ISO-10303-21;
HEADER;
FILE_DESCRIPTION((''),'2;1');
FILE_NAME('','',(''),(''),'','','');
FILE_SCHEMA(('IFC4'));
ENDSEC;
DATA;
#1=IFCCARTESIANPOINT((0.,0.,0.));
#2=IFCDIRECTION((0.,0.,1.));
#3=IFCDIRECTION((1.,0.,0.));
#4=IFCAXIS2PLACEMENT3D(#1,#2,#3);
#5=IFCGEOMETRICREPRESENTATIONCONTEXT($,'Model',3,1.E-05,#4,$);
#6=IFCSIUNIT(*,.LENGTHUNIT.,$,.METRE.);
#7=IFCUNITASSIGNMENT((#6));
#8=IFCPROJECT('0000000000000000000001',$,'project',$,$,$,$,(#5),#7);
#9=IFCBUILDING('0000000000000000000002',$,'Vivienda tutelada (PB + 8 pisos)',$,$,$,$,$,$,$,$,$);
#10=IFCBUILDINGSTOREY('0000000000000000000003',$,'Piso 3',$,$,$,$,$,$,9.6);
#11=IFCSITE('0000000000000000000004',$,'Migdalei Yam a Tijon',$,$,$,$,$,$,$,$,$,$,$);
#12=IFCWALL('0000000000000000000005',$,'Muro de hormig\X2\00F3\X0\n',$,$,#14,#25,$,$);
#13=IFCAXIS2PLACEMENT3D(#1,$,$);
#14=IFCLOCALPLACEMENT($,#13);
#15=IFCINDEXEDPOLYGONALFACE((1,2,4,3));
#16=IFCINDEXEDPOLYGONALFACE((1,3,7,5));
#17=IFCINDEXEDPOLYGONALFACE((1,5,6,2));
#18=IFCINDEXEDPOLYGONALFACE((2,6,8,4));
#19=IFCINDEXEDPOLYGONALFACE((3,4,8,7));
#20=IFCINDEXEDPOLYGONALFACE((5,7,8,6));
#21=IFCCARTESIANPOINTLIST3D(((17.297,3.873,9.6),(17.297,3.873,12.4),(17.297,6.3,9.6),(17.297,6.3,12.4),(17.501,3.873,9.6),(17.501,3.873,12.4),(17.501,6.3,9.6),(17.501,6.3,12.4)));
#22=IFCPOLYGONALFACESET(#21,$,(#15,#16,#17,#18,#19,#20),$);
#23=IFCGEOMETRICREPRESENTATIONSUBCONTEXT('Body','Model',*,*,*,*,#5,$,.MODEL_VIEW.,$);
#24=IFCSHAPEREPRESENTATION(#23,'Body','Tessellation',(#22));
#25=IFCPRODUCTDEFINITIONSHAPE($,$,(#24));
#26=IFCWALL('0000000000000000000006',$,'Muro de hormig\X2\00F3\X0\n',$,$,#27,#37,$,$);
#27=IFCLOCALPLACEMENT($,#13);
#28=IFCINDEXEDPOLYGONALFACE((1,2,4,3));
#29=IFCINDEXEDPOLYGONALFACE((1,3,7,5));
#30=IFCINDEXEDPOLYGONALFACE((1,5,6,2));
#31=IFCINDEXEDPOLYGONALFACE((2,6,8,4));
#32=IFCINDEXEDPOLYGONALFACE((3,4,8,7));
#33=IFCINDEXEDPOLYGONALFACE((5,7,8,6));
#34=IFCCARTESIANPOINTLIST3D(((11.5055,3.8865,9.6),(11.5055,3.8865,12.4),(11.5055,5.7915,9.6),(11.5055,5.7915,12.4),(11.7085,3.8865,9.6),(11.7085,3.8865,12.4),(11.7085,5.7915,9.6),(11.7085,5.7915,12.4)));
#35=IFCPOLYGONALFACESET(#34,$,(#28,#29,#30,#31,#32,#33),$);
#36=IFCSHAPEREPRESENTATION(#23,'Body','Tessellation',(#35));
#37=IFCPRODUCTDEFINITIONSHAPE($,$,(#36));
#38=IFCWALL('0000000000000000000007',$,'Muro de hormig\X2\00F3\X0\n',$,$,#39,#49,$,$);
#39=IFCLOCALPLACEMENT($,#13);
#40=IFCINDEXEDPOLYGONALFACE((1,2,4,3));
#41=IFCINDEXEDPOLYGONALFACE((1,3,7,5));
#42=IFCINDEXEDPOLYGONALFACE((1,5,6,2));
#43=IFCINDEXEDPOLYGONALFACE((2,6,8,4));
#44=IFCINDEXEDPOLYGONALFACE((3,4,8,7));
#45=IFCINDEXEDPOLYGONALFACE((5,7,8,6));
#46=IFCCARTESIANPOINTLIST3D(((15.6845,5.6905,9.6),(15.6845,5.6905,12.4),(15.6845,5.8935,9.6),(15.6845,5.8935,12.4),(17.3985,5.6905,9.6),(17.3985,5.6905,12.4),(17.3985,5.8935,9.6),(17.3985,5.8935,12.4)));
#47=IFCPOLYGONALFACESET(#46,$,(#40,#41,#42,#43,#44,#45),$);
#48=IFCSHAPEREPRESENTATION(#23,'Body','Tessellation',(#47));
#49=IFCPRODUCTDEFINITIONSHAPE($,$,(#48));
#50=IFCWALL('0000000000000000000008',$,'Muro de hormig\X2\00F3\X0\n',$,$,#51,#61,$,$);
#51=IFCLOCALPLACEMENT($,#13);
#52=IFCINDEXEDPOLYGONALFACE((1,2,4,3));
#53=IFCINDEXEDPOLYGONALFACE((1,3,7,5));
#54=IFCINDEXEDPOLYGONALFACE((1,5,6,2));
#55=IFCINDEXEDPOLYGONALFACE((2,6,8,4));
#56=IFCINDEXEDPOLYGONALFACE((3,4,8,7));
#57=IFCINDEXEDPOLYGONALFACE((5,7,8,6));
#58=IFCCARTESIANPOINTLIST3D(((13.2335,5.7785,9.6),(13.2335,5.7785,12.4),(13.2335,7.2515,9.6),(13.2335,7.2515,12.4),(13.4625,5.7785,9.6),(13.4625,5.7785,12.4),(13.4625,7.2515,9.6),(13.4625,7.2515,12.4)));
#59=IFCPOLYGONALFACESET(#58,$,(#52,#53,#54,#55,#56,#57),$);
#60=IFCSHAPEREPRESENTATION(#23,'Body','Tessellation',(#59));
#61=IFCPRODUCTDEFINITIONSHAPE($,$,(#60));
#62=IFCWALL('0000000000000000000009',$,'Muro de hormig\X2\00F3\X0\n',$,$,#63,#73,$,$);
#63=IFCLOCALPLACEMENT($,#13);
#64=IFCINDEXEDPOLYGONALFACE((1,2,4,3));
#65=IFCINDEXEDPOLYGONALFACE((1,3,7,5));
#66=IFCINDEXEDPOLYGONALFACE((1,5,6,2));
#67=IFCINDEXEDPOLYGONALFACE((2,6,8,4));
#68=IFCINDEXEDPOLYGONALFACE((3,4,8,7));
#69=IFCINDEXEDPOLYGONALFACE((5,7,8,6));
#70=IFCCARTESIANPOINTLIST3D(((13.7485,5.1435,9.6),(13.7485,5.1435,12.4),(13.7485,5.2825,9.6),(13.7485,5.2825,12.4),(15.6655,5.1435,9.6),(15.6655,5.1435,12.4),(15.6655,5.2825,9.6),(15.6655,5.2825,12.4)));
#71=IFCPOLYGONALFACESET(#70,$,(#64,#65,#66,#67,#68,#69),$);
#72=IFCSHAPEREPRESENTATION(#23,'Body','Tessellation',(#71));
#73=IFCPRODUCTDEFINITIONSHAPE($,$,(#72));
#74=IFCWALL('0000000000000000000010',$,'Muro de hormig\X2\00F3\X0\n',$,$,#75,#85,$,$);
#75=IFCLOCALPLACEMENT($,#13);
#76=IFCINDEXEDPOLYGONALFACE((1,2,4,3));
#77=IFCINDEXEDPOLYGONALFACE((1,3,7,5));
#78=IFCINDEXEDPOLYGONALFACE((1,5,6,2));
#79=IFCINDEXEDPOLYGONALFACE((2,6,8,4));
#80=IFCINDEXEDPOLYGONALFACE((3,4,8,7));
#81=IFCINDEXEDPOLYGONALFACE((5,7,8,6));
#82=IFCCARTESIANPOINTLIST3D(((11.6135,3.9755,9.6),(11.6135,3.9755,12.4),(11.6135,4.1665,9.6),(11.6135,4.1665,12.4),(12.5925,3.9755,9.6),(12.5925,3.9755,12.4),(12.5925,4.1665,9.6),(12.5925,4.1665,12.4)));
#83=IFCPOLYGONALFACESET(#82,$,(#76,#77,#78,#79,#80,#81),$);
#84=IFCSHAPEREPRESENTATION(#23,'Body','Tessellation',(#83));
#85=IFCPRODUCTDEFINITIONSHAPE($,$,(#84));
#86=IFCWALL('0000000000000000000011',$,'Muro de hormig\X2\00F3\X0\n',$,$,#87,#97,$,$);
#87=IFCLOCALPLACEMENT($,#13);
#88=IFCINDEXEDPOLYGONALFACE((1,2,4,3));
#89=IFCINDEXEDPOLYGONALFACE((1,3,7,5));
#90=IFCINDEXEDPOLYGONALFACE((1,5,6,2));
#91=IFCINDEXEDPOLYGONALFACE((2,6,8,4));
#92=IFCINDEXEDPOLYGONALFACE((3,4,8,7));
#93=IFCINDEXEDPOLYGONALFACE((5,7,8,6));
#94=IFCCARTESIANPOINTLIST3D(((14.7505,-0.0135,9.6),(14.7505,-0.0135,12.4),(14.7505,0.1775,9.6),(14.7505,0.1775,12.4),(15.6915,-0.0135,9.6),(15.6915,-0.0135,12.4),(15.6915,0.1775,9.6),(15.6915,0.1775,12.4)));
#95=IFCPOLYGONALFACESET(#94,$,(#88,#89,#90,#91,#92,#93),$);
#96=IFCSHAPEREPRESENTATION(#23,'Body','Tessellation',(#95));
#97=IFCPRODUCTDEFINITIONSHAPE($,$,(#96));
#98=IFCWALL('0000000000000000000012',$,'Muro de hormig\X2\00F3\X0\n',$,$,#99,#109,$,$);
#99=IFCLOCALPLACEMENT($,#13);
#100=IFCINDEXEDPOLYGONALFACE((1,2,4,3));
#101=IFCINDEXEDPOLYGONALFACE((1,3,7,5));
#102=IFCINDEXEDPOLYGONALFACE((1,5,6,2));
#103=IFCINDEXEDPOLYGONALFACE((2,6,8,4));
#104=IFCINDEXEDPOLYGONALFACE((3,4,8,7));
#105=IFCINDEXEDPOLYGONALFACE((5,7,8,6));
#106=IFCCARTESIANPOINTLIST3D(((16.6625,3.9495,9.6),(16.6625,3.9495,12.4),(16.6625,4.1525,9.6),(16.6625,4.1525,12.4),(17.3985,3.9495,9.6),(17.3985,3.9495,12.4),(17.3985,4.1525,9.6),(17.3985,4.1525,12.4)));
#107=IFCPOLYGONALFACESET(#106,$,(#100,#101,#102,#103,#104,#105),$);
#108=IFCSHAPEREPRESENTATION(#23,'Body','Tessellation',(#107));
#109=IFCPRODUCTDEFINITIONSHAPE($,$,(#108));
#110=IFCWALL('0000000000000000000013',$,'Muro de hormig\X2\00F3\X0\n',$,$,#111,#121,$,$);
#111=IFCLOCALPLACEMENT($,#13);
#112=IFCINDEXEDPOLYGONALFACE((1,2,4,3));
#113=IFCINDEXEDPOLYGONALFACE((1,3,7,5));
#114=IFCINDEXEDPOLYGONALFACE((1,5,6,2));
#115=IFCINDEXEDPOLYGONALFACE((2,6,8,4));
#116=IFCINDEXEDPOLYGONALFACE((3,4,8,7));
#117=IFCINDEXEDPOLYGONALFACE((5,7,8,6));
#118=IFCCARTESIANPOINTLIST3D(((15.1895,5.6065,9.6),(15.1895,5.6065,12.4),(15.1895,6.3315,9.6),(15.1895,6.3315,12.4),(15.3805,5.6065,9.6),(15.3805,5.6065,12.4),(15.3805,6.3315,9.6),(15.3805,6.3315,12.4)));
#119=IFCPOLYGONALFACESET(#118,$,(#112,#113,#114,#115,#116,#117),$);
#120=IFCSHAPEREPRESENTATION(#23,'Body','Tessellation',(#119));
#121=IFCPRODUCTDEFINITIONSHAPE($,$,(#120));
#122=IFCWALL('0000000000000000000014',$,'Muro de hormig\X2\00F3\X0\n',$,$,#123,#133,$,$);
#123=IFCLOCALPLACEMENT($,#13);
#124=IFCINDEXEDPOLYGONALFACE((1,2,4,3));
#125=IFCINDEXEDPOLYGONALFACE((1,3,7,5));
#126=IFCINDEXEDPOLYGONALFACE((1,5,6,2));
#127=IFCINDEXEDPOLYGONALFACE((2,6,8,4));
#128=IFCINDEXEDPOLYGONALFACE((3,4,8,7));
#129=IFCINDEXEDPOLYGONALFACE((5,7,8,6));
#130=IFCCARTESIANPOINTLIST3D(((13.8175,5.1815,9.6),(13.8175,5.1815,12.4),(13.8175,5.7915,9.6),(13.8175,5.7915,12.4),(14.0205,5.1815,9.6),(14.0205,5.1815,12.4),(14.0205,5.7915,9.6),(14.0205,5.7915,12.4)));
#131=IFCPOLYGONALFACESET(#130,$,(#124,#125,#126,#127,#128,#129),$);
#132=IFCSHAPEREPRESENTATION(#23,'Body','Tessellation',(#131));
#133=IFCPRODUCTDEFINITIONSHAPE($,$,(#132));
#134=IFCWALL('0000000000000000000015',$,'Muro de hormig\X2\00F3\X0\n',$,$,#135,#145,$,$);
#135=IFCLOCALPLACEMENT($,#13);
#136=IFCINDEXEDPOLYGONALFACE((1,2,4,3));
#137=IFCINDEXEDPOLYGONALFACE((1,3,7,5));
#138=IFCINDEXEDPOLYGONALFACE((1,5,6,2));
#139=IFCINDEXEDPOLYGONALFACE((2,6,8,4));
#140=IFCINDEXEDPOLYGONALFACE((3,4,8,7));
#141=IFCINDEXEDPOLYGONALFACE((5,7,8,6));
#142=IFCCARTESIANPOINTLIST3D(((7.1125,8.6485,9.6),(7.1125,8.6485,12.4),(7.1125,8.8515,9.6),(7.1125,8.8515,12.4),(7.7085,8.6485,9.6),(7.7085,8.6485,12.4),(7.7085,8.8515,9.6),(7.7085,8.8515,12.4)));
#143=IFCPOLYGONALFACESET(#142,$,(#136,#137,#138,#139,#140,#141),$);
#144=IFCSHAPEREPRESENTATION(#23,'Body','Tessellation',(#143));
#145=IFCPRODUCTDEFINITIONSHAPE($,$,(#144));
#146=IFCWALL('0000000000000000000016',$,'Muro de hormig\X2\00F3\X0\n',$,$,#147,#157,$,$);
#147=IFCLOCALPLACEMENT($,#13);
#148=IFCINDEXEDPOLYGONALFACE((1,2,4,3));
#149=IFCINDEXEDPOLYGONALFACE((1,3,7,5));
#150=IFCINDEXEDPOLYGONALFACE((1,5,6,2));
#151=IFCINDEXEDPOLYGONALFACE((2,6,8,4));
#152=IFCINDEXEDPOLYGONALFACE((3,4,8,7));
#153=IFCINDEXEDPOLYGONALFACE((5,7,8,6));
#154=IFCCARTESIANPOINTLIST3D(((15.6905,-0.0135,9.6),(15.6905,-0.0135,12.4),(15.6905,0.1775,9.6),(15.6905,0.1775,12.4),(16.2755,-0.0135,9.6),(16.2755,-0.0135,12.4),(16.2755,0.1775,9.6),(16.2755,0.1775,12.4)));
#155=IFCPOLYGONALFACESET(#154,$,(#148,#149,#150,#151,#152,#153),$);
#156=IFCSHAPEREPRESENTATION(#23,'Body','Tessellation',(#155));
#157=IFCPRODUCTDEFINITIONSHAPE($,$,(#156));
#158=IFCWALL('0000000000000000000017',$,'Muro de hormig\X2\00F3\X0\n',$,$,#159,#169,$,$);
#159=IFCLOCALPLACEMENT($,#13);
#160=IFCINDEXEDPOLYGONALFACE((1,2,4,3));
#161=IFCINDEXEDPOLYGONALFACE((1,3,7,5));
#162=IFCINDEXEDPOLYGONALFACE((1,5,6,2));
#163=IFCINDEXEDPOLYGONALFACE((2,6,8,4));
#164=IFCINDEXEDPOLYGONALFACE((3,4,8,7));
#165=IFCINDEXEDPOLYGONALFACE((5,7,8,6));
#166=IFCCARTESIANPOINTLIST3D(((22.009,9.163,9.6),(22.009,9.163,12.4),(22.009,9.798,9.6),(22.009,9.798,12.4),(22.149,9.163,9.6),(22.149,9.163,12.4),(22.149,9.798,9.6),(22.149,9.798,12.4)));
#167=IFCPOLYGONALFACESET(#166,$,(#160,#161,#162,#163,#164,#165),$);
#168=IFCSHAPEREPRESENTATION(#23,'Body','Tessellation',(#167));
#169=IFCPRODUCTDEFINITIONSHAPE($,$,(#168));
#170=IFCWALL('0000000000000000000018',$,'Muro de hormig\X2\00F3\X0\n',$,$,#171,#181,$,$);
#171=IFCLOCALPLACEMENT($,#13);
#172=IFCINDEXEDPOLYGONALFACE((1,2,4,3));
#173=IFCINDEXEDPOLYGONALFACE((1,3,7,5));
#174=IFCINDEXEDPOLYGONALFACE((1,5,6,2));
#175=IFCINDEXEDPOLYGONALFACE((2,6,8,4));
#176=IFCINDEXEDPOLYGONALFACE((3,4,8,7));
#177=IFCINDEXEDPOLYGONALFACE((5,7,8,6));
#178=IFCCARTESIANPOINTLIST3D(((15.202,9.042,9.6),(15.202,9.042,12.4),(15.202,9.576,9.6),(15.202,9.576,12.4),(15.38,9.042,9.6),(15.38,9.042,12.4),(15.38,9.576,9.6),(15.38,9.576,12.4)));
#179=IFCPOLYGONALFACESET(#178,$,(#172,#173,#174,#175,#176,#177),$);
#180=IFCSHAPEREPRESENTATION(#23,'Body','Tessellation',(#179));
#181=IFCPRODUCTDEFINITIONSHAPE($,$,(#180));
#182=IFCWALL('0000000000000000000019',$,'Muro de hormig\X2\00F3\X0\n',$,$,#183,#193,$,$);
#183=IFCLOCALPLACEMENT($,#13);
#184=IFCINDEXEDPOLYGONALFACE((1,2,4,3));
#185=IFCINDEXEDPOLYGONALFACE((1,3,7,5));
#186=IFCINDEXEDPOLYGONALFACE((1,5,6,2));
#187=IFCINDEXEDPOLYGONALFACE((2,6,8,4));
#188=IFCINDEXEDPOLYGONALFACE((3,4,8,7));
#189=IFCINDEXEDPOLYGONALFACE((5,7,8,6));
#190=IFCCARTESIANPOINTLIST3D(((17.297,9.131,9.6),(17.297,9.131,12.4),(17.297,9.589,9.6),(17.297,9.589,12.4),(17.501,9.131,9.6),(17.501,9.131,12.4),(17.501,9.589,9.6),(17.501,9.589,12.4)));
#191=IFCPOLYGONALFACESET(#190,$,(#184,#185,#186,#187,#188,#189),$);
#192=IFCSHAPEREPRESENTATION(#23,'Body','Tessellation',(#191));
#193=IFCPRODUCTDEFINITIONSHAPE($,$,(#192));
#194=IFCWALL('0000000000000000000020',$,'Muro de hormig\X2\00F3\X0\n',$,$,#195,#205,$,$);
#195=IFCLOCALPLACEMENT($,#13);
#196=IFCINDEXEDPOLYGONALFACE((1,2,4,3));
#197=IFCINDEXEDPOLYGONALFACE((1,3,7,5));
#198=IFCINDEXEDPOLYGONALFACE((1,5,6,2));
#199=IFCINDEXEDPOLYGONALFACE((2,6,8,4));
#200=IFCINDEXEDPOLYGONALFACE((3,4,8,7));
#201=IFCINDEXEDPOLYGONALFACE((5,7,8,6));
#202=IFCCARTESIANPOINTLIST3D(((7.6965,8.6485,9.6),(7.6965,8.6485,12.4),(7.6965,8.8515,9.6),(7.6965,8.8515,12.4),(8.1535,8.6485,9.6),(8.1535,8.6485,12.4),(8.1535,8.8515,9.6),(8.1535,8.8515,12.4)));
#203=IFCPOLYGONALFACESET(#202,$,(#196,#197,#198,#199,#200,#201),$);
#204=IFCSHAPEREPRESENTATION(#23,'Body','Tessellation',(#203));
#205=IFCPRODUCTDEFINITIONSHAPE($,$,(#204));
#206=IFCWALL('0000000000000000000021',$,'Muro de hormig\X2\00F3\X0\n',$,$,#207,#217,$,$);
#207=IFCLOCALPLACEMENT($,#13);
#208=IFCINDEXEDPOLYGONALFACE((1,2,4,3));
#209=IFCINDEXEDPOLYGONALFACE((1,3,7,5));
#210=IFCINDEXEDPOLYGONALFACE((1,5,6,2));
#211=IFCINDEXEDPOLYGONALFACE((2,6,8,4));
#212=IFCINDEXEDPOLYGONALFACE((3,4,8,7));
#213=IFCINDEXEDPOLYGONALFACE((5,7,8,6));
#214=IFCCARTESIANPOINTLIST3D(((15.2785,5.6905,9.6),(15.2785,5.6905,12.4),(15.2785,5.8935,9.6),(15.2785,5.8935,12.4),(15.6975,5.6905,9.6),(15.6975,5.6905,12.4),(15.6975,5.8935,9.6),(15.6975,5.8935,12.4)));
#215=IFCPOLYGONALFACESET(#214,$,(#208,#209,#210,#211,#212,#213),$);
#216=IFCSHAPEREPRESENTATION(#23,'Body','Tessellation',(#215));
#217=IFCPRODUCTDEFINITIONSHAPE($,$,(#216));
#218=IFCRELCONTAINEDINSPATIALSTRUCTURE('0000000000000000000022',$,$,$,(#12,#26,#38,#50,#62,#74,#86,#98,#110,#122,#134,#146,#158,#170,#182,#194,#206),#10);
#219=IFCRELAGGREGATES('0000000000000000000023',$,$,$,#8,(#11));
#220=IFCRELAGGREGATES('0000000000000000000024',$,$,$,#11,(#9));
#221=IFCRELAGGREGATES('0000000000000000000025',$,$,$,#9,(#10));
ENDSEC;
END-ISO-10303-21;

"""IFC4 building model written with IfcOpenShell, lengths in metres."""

from ifc_helpers import new_model, si_unit, frame, origin_with_axes, context, subcontext, project, spatial, line, indexed_curve, outline, extrude, element, save


model = new_model("IFC4")

# Units and contexts
model_context = context("Model", 3, precision=1e-05, world=origin_with_axes())
body_context = subcontext(model_context, "Body", "Model", "MODEL_VIEW")
ifc_project = project(units=[si_unit("LENGTHUNIT", "METRE")], contexts=[model_context])

# Site, building, storey
site = spatial("IfcSite", under=ifc_project, Name="Migdalei Yam a Tijon")
building = spatial("IfcBuilding", under=site, Name="Vivienda tutelada (PB + 8 pisos)")
storey = spatial("IfcBuildingStorey", under=building, Name="Piso 3", Elevation=9.6)

# Walls
element("IfcWall", 1, inside=storey, Name="Muro de hormigón", context=body_context, shape_type="SweptSolid", body=[
    extrude(outline(indexed_curve([(0.0, 0.0), (0.204, 0.0), (0.204, 2.427), (0.0, 2.427)], segments=[line(1, 2, 3, 4, 1)])), frame((17.297, 3.873, 9.6), z_axis=(0.0, 0.0, 1.0), x_axis=(1.0, 0.0, 0.0)), (0.0, 0.0, 1.0), 2.8),
])
element("IfcWall", 2, inside=storey, Name="Muro de hormigón", context=body_context, shape_type="SweptSolid", body=[
    extrude(outline(indexed_curve([(0.0, 0.0), (0.203, 0.0), (0.203, 1.905), (0.0, 1.905)], segments=[line(1, 2, 3, 4, 1)])), frame((11.5055, 3.8865, 9.6), z_axis=(0.0, 0.0, 1.0), x_axis=(1.0, 0.0, 0.0)), (0.0, 0.0, 1.0), 2.8),
])
element("IfcWall", 3, inside=storey, Name="Muro de hormigón", context=body_context, shape_type="SweptSolid", body=[
    extrude(outline(indexed_curve([(0.0, 0.0), (1.714, 0.0), (1.714, 0.203), (0.0, 0.203)], segments=[line(1, 2, 3, 4, 1)])), frame((15.6845, 5.6905, 9.6), z_axis=(0.0, 0.0, 1.0), x_axis=(1.0, 0.0, 0.0)), (0.0, 0.0, 1.0), 2.8),
])
element("IfcWall", 4, inside=storey, Name="Muro de hormigón", context=body_context, shape_type="SweptSolid", body=[
    extrude(outline(indexed_curve([(0.0, 0.0), (0.229, 0.0), (0.229, 1.473), (0.0, 1.473)], segments=[line(1, 2, 3, 4, 1)])), frame((13.2335, 5.7785, 9.6), z_axis=(0.0, 0.0, 1.0), x_axis=(1.0, 0.0, 0.0)), (0.0, 0.0, 1.0), 2.8),
])
element("IfcWall", 5, inside=storey, Name="Muro de hormigón", context=body_context, shape_type="SweptSolid", body=[
    extrude(outline(indexed_curve([(0.0, 0.0), (1.917, 0.0), (1.917, 0.139), (0.0, 0.139)], segments=[line(1, 2, 3, 4, 1)])), frame((13.7485, 5.1435, 9.6), z_axis=(0.0, 0.0, 1.0), x_axis=(1.0, 0.0, 0.0)), (0.0, 0.0, 1.0), 2.8),
])
element("IfcWall", 6, inside=storey, Name="Muro de hormigón", context=body_context, shape_type="SweptSolid", body=[
    extrude(outline(indexed_curve([(0.0, 0.0), (0.979, 0.0), (0.979, 0.191), (0.0, 0.191)], segments=[line(1, 2, 3, 4, 1)])), frame((11.6135, 3.9755, 9.6), z_axis=(0.0, 0.0, 1.0), x_axis=(1.0, 0.0, 0.0)), (0.0, 0.0, 1.0), 2.8),
])
element("IfcWall", 7, inside=storey, Name="Muro de hormigón", context=body_context, shape_type="SweptSolid", body=[
    extrude(outline(indexed_curve([(0.0, 0.0), (0.941, 0.0), (0.941, 0.191), (0.0, 0.191)], segments=[line(1, 2, 3, 4, 1)])), frame((14.7505, -0.0135, 9.6), z_axis=(0.0, 0.0, 1.0), x_axis=(1.0, 0.0, 0.0)), (0.0, 0.0, 1.0), 2.8),
])
element("IfcWall", 8, inside=storey, Name="Muro de hormigón", context=body_context, shape_type="SweptSolid", body=[
    extrude(outline(indexed_curve([(0.0, 0.0), (0.736, 0.0), (0.736, 0.203), (0.0, 0.203)], segments=[line(1, 2, 3, 4, 1)])), frame((16.6625, 3.9495, 9.6), z_axis=(0.0, 0.0, 1.0), x_axis=(1.0, 0.0, 0.0)), (0.0, 0.0, 1.0), 2.8),
])
element("IfcWall", 9, inside=storey, Name="Muro de hormigón", context=body_context, shape_type="SweptSolid", body=[
    extrude(outline(indexed_curve([(0.0, 0.0), (0.191, 0.0), (0.191, 0.725), (0.0, 0.725)], segments=[line(1, 2, 3, 4, 1)])), frame((15.1895, 5.6065, 9.6), z_axis=(0.0, 0.0, 1.0), x_axis=(1.0, 0.0, 0.0)), (0.0, 0.0, 1.0), 2.8),
])
element("IfcWall", 10, inside=storey, Name="Muro de hormigón", context=body_context, shape_type="SweptSolid", body=[
    extrude(outline(indexed_curve([(0.0, 0.0), (0.203, 0.0), (0.203, 0.61), (0.0, 0.61)], segments=[line(1, 2, 3, 4, 1)])), frame((13.8175, 5.1815, 9.6), z_axis=(0.0, 0.0, 1.0), x_axis=(1.0, 0.0, 0.0)), (0.0, 0.0, 1.0), 2.8),
])
element("IfcWall", 11, inside=storey, Name="Muro de hormigón", context=body_context, shape_type="SweptSolid", body=[
    extrude(outline(indexed_curve([(0.0, 0.0), (0.596, 0.0), (0.596, 0.203), (0.0, 0.203)], segments=[line(1, 2, 3, 4, 1)])), frame((7.1125, 8.6485, 9.6), z_axis=(0.0, 0.0, 1.0), x_axis=(1.0, 0.0, 0.0)), (0.0, 0.0, 1.0), 2.8),
])
element("IfcWall", 12, inside=storey, Name="Muro de hormigón", context=body_context, shape_type="SweptSolid", body=[
    extrude(outline(indexed_curve([(0.0, 0.0), (0.585, 0.0), (0.585, 0.191), (0.0, 0.191)], segments=[line(1, 2, 3, 4, 1)])), frame((15.6905, -0.0135, 9.6), z_axis=(0.0, 0.0, 1.0), x_axis=(1.0, 0.0, 0.0)), (0.0, 0.0, 1.0), 2.8),
])
element("IfcWall", 13, inside=storey, Name="Muro de hormigón", context=body_context, shape_type="SweptSolid", body=[
    extrude(outline(indexed_curve([(0.0, 0.0), (0.14, 0.0), (0.14, 0.635), (0.0, 0.635)], segments=[line(1, 2, 3, 4, 1)])), frame((22.009, 9.163, 9.6), z_axis=(0.0, 0.0, 1.0), x_axis=(1.0, 0.0, 0.0)), (0.0, 0.0, 1.0), 2.8),
])
element("IfcWall", 14, inside=storey, Name="Muro de hormigón", context=body_context, shape_type="SweptSolid", body=[
    extrude(outline(indexed_curve([(0.0, 0.0), (0.178, 0.0), (0.178, 0.534), (0.0, 0.534)], segments=[line(1, 2, 3, 4, 1)])), frame((15.202, 9.042, 9.6), z_axis=(0.0, 0.0, 1.0), x_axis=(1.0, 0.0, 0.0)), (0.0, 0.0, 1.0), 2.8),
])
element("IfcWall", 15, inside=storey, Name="Muro de hormigón", context=body_context, shape_type="SweptSolid", body=[
    extrude(outline(indexed_curve([(0.0, 0.0), (0.204, 0.0), (0.204, 0.458), (0.0, 0.458)], segments=[line(1, 2, 3, 4, 1)])), frame((17.297, 9.131, 9.6), z_axis=(0.0, 0.0, 1.0), x_axis=(1.0, 0.0, 0.0)), (0.0, 0.0, 1.0), 2.8),
])
element("IfcWall", 16, inside=storey, Name="Muro de hormigón", context=body_context, shape_type="SweptSolid", body=[
    extrude(outline(indexed_curve([(0.0, 0.0), (0.457, 0.0), (0.457, 0.203), (0.0, 0.203)], segments=[line(1, 2, 3, 4, 1)])), frame((7.6965, 8.6485, 9.6), z_axis=(0.0, 0.0, 1.0), x_axis=(1.0, 0.0, 0.0)), (0.0, 0.0, 1.0), 2.8),
])
element("IfcWall", 17, inside=storey, Name="Muro de hormigón", context=body_context, shape_type="SweptSolid", body=[
    extrude(outline(indexed_curve([(0.0, 0.0), (0.419, 0.0), (0.419, 0.203), (0.0, 0.203)], segments=[line(1, 2, 3, 4, 1)])), frame((15.2785, 5.6905, 9.6), z_axis=(0.0, 0.0, 1.0), x_axis=(1.0, 0.0, 0.0)), (0.0, 0.0, 1.0), 2.8),
])

save(model, "model.ifc")
